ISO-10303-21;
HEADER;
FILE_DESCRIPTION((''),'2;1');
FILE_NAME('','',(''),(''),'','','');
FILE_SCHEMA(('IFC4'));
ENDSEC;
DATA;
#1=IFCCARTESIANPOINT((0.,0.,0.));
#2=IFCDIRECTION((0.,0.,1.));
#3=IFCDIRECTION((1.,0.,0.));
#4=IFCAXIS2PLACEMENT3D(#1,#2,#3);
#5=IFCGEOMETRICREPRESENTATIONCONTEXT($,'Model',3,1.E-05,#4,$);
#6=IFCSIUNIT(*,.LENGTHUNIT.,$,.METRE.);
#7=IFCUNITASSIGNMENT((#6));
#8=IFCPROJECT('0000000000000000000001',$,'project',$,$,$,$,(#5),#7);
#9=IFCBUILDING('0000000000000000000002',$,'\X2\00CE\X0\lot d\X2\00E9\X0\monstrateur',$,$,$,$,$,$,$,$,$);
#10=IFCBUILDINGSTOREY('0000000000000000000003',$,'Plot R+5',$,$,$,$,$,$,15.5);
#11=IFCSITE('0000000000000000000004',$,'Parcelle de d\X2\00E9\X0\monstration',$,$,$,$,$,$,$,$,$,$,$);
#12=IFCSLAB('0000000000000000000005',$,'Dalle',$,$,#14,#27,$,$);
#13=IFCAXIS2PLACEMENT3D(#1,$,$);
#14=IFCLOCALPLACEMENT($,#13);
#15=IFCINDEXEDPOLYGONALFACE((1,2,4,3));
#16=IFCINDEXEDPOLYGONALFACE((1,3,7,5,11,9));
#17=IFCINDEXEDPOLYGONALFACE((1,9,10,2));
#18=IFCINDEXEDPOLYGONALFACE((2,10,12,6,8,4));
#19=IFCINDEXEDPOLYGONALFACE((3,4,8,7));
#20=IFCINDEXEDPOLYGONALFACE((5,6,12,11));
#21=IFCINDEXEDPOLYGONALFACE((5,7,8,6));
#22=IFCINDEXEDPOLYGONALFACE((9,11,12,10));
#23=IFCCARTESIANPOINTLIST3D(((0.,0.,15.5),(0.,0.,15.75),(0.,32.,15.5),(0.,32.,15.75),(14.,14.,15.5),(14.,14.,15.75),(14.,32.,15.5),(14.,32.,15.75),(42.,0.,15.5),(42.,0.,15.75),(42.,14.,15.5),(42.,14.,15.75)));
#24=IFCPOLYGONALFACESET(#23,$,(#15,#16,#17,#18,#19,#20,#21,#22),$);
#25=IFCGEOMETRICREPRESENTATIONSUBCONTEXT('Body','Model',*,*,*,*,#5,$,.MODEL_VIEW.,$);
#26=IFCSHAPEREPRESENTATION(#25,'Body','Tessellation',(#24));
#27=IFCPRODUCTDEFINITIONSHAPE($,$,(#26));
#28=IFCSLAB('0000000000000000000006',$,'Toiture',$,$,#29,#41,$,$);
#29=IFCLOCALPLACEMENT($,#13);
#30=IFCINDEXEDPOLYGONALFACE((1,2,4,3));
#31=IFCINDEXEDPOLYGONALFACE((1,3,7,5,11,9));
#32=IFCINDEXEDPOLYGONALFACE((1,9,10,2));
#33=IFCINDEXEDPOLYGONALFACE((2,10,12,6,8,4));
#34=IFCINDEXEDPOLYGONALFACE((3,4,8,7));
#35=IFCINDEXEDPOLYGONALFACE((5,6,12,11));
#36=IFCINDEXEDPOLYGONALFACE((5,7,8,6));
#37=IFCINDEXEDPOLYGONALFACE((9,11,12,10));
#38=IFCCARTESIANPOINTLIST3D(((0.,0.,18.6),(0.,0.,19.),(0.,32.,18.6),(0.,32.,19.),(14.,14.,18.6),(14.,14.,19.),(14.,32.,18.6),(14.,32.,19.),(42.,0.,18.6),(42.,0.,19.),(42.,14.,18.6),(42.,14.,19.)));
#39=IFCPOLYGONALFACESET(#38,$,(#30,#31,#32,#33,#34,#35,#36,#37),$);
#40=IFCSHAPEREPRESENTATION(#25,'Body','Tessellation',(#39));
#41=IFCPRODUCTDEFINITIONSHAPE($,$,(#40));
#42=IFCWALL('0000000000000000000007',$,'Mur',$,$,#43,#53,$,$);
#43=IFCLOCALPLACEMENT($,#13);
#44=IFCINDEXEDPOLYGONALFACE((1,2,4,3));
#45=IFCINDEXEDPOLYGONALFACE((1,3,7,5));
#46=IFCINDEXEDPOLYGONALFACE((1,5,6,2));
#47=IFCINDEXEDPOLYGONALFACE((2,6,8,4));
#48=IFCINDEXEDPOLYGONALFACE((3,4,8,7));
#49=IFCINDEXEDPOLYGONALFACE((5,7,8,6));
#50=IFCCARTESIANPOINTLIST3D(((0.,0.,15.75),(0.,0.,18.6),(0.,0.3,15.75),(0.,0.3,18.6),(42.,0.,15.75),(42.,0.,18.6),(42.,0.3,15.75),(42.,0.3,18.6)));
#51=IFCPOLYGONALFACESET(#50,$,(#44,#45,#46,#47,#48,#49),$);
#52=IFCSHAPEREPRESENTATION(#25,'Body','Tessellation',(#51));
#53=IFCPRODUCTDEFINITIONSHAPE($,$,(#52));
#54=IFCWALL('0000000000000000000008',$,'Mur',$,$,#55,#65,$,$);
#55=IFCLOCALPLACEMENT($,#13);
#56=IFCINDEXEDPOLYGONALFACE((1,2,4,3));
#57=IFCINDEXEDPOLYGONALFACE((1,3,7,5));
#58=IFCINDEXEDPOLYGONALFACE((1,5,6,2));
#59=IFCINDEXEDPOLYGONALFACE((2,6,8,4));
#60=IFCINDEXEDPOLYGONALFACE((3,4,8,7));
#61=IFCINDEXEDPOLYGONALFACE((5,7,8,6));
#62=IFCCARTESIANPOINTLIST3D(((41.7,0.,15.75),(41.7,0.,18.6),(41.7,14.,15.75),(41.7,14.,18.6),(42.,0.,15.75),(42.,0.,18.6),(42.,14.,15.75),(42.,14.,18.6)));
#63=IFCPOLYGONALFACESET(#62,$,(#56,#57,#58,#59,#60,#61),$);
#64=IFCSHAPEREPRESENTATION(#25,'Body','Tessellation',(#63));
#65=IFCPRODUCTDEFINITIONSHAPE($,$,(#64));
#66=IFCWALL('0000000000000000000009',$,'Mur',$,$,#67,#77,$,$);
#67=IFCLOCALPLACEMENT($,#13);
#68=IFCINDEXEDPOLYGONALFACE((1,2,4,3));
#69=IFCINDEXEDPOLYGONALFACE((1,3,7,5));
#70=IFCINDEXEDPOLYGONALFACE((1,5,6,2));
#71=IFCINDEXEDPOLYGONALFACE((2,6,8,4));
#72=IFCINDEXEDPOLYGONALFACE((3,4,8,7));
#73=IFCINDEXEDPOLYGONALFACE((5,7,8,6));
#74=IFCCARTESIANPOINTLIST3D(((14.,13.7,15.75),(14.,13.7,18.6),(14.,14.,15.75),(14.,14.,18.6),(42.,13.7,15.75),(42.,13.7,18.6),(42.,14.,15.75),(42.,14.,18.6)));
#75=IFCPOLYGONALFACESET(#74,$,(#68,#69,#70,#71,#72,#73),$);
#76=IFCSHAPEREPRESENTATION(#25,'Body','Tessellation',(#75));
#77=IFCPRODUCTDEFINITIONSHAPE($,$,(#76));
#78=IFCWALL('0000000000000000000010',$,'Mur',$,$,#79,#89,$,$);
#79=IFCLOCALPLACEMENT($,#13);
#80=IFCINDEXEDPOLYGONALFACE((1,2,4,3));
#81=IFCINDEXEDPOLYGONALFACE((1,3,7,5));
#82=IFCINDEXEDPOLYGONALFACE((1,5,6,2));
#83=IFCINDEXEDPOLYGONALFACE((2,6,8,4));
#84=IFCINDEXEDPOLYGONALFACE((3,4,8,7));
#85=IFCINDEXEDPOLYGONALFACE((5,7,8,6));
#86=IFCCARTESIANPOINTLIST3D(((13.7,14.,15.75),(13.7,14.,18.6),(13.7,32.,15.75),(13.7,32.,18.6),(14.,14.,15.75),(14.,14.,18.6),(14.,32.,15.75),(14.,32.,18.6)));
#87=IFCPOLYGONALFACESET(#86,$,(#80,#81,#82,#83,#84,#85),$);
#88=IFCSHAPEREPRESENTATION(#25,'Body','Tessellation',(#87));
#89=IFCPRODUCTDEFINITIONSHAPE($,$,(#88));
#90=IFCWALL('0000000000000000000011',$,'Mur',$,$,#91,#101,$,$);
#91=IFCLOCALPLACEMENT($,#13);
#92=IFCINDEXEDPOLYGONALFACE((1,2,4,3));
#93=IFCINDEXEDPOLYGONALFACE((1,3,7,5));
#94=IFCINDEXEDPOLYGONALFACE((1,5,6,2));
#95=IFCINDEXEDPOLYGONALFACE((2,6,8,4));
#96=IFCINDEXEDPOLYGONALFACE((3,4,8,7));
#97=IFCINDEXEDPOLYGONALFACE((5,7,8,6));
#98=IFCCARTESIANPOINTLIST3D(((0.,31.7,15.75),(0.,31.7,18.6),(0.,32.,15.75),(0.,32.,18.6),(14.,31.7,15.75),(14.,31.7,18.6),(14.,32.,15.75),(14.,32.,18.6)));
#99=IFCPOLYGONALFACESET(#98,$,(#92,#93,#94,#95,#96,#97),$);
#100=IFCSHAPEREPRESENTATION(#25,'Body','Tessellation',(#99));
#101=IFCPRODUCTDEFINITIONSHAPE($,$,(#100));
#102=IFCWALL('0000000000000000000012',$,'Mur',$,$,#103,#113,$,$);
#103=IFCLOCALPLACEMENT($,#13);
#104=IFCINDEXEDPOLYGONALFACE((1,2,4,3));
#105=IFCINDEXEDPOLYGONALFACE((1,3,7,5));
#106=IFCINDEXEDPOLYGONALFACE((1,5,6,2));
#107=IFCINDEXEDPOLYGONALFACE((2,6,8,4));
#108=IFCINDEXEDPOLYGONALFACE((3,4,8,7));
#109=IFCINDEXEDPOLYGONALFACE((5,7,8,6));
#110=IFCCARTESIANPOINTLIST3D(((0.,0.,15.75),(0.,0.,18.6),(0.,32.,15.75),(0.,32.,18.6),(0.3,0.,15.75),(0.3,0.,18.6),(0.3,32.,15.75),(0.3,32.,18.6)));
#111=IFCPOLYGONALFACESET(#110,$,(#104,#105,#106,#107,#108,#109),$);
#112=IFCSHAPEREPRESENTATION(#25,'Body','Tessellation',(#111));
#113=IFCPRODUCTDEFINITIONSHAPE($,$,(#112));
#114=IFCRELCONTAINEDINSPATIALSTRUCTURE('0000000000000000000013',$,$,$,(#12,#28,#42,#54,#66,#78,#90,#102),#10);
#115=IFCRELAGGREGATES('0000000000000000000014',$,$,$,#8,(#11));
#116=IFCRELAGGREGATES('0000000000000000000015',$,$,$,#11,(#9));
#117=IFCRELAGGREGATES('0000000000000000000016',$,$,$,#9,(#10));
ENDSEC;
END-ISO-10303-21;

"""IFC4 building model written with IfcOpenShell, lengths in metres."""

from ifc_helpers import new_model, si_unit, frame, origin_with_axes, place, context, subcontext, project, spatial, indexed_curve, outline, extrude, element, save


model = new_model("IFC4")

# Units and contexts
model_context = context("Model", 3, precision=1e-05, world=origin_with_axes())
body_context = subcontext(model_context, "Body", "Model", "MODEL_VIEW")
ifc_project = project(units=[si_unit("LENGTHUNIT", "METRE")], contexts=[model_context])

# Site, building, storey
site = spatial("IfcSite", under=ifc_project, Name="Parcelle de démonstration")
building = spatial("IfcBuilding", under=site, Name="Îlot démonstrateur")
storey = spatial("IfcBuildingStorey", under=building, Name="Plot R+5", Elevation=15.5)

# Slabs
slab_1_placement = place(None, frame((0.0, 0.0, 15.5), z_axis=(0.0, 0.0, 1.0), x_axis=(1.0, 0.0, 0.0)))
element("IfcSlab", 1, at=slab_1_placement, inside=storey, Name="Dalle", context=body_context, shape_type="SweptSolid", body=[
    extrude(outline(indexed_curve([(0.0, 0.0), (42.0, 0.0), (42.0, 14.0), (14.0, 14.0), (14.0, 32.0), (0.0, 32.0)])), None, (0.0, 0.0, 1.0), 0.25),
])
slab_2_placement = place(None, frame((0.0, 0.0, 18.6), z_axis=(0.0, 0.0, 1.0), x_axis=(1.0, 0.0, 0.0)))
element("IfcSlab", 2, at=slab_2_placement, inside=storey, Name="Toiture", context=body_context, shape_type="SweptSolid", body=[
    extrude(outline(indexed_curve([(0.0, 0.0), (42.0, 0.0), (42.0, 14.0), (14.0, 14.0), (14.0, 32.0), (0.0, 32.0)])), None, (0.0, 0.0, 1.0), 0.4),
])

# Walls
wall_1_placement = place(None, frame((0.0, 0.0, 15.75), z_axis=(0.0, 0.0, 1.0), x_axis=(1.0, 0.0, 0.0)))
element("IfcWall", 3, at=wall_1_placement, inside=storey, Name="Mur", context=body_context, shape_type="SweptSolid", body=[
    extrude(outline(indexed_curve([(0.0, 0.0), (0.0, 0.3), (42.0, 0.3), (42.0, 0.0), (0.0, 0.0)], self_intersect=False)), origin_with_axes(), (0.0, 0.0, 1.0), 2.85),
])
wall_2_placement = place(None, frame((42.0, 0.0, 15.75), z_axis=(0.0, 0.0, 1.0), x_axis=(0.0, 1.0, 0.0)))
element("IfcWall", 4, at=wall_2_placement, inside=storey, Name="Mur", context=body_context, shape_type="SweptSolid", body=[
    extrude(outline(indexed_curve([(0.0, 0.0), (0.0, 0.3), (14.0, 0.3), (14.0, 0.0), (0.0, 0.0)], self_intersect=False)), origin_with_axes(), (0.0, 0.0, 1.0), 2.85),
])
wall_3_placement = place(None, frame((42.0, 14.0, 15.75), z_axis=(0.0, 0.0, 1.0), x_axis=(-1.0, 0.0, 0.0)))
element("IfcWall", 5, at=wall_3_placement, inside=storey, Name="Mur", context=body_context, shape_type="SweptSolid", body=[
    extrude(outline(indexed_curve([(0.0, 0.0), (0.0, 0.3), (28.0, 0.3), (28.0, 0.0), (0.0, 0.0)], self_intersect=False)), origin_with_axes(), (0.0, 0.0, 1.0), 2.85),
])
wall_4_placement = place(None, frame((14.0, 14.0, 15.75), z_axis=(0.0, 0.0, 1.0), x_axis=(0.0, 1.0, 0.0)))
element("IfcWall", 6, at=wall_4_placement, inside=storey, Name="Mur", context=body_context, shape_type="SweptSolid", body=[
    extrude(outline(indexed_curve([(0.0, 0.0), (0.0, 0.3), (18.0, 0.3), (18.0, 0.0), (0.0, 0.0)], self_intersect=False)), origin_with_axes(), (0.0, 0.0, 1.0), 2.85),
])
wall_5_placement = place(None, frame((14.0, 32.0, 15.75), z_axis=(0.0, 0.0, 1.0), x_axis=(-1.0, 0.0, 0.0)))
element("IfcWall", 7, at=wall_5_placement, inside=storey, Name="Mur", context=body_context, shape_type="SweptSolid", body=[
    extrude(outline(indexed_curve([(0.0, 0.0), (0.0, 0.3), (14.0, 0.3), (14.0, 0.0), (0.0, 0.0)], self_intersect=False)), origin_with_axes(), (0.0, 0.0, 1.0), 2.85),
])
wall_6_placement = place(None, frame((0.0, 32.0, 15.75), z_axis=(0.0, 0.0, 1.0), x_axis=(0.0, -1.0, 0.0)))
element("IfcWall", 8, at=wall_6_placement, inside=storey, Name="Mur", context=body_context, shape_type="SweptSolid", body=[
    extrude(outline(indexed_curve([(0.0, 0.0), (0.0, 0.3), (32.0, 0.3), (32.0, 0.0), (0.0, 0.0)], self_intersect=False)), origin_with_axes(), (0.0, 0.0, 1.0), 2.85),
])

save(model, "model.ifc")
